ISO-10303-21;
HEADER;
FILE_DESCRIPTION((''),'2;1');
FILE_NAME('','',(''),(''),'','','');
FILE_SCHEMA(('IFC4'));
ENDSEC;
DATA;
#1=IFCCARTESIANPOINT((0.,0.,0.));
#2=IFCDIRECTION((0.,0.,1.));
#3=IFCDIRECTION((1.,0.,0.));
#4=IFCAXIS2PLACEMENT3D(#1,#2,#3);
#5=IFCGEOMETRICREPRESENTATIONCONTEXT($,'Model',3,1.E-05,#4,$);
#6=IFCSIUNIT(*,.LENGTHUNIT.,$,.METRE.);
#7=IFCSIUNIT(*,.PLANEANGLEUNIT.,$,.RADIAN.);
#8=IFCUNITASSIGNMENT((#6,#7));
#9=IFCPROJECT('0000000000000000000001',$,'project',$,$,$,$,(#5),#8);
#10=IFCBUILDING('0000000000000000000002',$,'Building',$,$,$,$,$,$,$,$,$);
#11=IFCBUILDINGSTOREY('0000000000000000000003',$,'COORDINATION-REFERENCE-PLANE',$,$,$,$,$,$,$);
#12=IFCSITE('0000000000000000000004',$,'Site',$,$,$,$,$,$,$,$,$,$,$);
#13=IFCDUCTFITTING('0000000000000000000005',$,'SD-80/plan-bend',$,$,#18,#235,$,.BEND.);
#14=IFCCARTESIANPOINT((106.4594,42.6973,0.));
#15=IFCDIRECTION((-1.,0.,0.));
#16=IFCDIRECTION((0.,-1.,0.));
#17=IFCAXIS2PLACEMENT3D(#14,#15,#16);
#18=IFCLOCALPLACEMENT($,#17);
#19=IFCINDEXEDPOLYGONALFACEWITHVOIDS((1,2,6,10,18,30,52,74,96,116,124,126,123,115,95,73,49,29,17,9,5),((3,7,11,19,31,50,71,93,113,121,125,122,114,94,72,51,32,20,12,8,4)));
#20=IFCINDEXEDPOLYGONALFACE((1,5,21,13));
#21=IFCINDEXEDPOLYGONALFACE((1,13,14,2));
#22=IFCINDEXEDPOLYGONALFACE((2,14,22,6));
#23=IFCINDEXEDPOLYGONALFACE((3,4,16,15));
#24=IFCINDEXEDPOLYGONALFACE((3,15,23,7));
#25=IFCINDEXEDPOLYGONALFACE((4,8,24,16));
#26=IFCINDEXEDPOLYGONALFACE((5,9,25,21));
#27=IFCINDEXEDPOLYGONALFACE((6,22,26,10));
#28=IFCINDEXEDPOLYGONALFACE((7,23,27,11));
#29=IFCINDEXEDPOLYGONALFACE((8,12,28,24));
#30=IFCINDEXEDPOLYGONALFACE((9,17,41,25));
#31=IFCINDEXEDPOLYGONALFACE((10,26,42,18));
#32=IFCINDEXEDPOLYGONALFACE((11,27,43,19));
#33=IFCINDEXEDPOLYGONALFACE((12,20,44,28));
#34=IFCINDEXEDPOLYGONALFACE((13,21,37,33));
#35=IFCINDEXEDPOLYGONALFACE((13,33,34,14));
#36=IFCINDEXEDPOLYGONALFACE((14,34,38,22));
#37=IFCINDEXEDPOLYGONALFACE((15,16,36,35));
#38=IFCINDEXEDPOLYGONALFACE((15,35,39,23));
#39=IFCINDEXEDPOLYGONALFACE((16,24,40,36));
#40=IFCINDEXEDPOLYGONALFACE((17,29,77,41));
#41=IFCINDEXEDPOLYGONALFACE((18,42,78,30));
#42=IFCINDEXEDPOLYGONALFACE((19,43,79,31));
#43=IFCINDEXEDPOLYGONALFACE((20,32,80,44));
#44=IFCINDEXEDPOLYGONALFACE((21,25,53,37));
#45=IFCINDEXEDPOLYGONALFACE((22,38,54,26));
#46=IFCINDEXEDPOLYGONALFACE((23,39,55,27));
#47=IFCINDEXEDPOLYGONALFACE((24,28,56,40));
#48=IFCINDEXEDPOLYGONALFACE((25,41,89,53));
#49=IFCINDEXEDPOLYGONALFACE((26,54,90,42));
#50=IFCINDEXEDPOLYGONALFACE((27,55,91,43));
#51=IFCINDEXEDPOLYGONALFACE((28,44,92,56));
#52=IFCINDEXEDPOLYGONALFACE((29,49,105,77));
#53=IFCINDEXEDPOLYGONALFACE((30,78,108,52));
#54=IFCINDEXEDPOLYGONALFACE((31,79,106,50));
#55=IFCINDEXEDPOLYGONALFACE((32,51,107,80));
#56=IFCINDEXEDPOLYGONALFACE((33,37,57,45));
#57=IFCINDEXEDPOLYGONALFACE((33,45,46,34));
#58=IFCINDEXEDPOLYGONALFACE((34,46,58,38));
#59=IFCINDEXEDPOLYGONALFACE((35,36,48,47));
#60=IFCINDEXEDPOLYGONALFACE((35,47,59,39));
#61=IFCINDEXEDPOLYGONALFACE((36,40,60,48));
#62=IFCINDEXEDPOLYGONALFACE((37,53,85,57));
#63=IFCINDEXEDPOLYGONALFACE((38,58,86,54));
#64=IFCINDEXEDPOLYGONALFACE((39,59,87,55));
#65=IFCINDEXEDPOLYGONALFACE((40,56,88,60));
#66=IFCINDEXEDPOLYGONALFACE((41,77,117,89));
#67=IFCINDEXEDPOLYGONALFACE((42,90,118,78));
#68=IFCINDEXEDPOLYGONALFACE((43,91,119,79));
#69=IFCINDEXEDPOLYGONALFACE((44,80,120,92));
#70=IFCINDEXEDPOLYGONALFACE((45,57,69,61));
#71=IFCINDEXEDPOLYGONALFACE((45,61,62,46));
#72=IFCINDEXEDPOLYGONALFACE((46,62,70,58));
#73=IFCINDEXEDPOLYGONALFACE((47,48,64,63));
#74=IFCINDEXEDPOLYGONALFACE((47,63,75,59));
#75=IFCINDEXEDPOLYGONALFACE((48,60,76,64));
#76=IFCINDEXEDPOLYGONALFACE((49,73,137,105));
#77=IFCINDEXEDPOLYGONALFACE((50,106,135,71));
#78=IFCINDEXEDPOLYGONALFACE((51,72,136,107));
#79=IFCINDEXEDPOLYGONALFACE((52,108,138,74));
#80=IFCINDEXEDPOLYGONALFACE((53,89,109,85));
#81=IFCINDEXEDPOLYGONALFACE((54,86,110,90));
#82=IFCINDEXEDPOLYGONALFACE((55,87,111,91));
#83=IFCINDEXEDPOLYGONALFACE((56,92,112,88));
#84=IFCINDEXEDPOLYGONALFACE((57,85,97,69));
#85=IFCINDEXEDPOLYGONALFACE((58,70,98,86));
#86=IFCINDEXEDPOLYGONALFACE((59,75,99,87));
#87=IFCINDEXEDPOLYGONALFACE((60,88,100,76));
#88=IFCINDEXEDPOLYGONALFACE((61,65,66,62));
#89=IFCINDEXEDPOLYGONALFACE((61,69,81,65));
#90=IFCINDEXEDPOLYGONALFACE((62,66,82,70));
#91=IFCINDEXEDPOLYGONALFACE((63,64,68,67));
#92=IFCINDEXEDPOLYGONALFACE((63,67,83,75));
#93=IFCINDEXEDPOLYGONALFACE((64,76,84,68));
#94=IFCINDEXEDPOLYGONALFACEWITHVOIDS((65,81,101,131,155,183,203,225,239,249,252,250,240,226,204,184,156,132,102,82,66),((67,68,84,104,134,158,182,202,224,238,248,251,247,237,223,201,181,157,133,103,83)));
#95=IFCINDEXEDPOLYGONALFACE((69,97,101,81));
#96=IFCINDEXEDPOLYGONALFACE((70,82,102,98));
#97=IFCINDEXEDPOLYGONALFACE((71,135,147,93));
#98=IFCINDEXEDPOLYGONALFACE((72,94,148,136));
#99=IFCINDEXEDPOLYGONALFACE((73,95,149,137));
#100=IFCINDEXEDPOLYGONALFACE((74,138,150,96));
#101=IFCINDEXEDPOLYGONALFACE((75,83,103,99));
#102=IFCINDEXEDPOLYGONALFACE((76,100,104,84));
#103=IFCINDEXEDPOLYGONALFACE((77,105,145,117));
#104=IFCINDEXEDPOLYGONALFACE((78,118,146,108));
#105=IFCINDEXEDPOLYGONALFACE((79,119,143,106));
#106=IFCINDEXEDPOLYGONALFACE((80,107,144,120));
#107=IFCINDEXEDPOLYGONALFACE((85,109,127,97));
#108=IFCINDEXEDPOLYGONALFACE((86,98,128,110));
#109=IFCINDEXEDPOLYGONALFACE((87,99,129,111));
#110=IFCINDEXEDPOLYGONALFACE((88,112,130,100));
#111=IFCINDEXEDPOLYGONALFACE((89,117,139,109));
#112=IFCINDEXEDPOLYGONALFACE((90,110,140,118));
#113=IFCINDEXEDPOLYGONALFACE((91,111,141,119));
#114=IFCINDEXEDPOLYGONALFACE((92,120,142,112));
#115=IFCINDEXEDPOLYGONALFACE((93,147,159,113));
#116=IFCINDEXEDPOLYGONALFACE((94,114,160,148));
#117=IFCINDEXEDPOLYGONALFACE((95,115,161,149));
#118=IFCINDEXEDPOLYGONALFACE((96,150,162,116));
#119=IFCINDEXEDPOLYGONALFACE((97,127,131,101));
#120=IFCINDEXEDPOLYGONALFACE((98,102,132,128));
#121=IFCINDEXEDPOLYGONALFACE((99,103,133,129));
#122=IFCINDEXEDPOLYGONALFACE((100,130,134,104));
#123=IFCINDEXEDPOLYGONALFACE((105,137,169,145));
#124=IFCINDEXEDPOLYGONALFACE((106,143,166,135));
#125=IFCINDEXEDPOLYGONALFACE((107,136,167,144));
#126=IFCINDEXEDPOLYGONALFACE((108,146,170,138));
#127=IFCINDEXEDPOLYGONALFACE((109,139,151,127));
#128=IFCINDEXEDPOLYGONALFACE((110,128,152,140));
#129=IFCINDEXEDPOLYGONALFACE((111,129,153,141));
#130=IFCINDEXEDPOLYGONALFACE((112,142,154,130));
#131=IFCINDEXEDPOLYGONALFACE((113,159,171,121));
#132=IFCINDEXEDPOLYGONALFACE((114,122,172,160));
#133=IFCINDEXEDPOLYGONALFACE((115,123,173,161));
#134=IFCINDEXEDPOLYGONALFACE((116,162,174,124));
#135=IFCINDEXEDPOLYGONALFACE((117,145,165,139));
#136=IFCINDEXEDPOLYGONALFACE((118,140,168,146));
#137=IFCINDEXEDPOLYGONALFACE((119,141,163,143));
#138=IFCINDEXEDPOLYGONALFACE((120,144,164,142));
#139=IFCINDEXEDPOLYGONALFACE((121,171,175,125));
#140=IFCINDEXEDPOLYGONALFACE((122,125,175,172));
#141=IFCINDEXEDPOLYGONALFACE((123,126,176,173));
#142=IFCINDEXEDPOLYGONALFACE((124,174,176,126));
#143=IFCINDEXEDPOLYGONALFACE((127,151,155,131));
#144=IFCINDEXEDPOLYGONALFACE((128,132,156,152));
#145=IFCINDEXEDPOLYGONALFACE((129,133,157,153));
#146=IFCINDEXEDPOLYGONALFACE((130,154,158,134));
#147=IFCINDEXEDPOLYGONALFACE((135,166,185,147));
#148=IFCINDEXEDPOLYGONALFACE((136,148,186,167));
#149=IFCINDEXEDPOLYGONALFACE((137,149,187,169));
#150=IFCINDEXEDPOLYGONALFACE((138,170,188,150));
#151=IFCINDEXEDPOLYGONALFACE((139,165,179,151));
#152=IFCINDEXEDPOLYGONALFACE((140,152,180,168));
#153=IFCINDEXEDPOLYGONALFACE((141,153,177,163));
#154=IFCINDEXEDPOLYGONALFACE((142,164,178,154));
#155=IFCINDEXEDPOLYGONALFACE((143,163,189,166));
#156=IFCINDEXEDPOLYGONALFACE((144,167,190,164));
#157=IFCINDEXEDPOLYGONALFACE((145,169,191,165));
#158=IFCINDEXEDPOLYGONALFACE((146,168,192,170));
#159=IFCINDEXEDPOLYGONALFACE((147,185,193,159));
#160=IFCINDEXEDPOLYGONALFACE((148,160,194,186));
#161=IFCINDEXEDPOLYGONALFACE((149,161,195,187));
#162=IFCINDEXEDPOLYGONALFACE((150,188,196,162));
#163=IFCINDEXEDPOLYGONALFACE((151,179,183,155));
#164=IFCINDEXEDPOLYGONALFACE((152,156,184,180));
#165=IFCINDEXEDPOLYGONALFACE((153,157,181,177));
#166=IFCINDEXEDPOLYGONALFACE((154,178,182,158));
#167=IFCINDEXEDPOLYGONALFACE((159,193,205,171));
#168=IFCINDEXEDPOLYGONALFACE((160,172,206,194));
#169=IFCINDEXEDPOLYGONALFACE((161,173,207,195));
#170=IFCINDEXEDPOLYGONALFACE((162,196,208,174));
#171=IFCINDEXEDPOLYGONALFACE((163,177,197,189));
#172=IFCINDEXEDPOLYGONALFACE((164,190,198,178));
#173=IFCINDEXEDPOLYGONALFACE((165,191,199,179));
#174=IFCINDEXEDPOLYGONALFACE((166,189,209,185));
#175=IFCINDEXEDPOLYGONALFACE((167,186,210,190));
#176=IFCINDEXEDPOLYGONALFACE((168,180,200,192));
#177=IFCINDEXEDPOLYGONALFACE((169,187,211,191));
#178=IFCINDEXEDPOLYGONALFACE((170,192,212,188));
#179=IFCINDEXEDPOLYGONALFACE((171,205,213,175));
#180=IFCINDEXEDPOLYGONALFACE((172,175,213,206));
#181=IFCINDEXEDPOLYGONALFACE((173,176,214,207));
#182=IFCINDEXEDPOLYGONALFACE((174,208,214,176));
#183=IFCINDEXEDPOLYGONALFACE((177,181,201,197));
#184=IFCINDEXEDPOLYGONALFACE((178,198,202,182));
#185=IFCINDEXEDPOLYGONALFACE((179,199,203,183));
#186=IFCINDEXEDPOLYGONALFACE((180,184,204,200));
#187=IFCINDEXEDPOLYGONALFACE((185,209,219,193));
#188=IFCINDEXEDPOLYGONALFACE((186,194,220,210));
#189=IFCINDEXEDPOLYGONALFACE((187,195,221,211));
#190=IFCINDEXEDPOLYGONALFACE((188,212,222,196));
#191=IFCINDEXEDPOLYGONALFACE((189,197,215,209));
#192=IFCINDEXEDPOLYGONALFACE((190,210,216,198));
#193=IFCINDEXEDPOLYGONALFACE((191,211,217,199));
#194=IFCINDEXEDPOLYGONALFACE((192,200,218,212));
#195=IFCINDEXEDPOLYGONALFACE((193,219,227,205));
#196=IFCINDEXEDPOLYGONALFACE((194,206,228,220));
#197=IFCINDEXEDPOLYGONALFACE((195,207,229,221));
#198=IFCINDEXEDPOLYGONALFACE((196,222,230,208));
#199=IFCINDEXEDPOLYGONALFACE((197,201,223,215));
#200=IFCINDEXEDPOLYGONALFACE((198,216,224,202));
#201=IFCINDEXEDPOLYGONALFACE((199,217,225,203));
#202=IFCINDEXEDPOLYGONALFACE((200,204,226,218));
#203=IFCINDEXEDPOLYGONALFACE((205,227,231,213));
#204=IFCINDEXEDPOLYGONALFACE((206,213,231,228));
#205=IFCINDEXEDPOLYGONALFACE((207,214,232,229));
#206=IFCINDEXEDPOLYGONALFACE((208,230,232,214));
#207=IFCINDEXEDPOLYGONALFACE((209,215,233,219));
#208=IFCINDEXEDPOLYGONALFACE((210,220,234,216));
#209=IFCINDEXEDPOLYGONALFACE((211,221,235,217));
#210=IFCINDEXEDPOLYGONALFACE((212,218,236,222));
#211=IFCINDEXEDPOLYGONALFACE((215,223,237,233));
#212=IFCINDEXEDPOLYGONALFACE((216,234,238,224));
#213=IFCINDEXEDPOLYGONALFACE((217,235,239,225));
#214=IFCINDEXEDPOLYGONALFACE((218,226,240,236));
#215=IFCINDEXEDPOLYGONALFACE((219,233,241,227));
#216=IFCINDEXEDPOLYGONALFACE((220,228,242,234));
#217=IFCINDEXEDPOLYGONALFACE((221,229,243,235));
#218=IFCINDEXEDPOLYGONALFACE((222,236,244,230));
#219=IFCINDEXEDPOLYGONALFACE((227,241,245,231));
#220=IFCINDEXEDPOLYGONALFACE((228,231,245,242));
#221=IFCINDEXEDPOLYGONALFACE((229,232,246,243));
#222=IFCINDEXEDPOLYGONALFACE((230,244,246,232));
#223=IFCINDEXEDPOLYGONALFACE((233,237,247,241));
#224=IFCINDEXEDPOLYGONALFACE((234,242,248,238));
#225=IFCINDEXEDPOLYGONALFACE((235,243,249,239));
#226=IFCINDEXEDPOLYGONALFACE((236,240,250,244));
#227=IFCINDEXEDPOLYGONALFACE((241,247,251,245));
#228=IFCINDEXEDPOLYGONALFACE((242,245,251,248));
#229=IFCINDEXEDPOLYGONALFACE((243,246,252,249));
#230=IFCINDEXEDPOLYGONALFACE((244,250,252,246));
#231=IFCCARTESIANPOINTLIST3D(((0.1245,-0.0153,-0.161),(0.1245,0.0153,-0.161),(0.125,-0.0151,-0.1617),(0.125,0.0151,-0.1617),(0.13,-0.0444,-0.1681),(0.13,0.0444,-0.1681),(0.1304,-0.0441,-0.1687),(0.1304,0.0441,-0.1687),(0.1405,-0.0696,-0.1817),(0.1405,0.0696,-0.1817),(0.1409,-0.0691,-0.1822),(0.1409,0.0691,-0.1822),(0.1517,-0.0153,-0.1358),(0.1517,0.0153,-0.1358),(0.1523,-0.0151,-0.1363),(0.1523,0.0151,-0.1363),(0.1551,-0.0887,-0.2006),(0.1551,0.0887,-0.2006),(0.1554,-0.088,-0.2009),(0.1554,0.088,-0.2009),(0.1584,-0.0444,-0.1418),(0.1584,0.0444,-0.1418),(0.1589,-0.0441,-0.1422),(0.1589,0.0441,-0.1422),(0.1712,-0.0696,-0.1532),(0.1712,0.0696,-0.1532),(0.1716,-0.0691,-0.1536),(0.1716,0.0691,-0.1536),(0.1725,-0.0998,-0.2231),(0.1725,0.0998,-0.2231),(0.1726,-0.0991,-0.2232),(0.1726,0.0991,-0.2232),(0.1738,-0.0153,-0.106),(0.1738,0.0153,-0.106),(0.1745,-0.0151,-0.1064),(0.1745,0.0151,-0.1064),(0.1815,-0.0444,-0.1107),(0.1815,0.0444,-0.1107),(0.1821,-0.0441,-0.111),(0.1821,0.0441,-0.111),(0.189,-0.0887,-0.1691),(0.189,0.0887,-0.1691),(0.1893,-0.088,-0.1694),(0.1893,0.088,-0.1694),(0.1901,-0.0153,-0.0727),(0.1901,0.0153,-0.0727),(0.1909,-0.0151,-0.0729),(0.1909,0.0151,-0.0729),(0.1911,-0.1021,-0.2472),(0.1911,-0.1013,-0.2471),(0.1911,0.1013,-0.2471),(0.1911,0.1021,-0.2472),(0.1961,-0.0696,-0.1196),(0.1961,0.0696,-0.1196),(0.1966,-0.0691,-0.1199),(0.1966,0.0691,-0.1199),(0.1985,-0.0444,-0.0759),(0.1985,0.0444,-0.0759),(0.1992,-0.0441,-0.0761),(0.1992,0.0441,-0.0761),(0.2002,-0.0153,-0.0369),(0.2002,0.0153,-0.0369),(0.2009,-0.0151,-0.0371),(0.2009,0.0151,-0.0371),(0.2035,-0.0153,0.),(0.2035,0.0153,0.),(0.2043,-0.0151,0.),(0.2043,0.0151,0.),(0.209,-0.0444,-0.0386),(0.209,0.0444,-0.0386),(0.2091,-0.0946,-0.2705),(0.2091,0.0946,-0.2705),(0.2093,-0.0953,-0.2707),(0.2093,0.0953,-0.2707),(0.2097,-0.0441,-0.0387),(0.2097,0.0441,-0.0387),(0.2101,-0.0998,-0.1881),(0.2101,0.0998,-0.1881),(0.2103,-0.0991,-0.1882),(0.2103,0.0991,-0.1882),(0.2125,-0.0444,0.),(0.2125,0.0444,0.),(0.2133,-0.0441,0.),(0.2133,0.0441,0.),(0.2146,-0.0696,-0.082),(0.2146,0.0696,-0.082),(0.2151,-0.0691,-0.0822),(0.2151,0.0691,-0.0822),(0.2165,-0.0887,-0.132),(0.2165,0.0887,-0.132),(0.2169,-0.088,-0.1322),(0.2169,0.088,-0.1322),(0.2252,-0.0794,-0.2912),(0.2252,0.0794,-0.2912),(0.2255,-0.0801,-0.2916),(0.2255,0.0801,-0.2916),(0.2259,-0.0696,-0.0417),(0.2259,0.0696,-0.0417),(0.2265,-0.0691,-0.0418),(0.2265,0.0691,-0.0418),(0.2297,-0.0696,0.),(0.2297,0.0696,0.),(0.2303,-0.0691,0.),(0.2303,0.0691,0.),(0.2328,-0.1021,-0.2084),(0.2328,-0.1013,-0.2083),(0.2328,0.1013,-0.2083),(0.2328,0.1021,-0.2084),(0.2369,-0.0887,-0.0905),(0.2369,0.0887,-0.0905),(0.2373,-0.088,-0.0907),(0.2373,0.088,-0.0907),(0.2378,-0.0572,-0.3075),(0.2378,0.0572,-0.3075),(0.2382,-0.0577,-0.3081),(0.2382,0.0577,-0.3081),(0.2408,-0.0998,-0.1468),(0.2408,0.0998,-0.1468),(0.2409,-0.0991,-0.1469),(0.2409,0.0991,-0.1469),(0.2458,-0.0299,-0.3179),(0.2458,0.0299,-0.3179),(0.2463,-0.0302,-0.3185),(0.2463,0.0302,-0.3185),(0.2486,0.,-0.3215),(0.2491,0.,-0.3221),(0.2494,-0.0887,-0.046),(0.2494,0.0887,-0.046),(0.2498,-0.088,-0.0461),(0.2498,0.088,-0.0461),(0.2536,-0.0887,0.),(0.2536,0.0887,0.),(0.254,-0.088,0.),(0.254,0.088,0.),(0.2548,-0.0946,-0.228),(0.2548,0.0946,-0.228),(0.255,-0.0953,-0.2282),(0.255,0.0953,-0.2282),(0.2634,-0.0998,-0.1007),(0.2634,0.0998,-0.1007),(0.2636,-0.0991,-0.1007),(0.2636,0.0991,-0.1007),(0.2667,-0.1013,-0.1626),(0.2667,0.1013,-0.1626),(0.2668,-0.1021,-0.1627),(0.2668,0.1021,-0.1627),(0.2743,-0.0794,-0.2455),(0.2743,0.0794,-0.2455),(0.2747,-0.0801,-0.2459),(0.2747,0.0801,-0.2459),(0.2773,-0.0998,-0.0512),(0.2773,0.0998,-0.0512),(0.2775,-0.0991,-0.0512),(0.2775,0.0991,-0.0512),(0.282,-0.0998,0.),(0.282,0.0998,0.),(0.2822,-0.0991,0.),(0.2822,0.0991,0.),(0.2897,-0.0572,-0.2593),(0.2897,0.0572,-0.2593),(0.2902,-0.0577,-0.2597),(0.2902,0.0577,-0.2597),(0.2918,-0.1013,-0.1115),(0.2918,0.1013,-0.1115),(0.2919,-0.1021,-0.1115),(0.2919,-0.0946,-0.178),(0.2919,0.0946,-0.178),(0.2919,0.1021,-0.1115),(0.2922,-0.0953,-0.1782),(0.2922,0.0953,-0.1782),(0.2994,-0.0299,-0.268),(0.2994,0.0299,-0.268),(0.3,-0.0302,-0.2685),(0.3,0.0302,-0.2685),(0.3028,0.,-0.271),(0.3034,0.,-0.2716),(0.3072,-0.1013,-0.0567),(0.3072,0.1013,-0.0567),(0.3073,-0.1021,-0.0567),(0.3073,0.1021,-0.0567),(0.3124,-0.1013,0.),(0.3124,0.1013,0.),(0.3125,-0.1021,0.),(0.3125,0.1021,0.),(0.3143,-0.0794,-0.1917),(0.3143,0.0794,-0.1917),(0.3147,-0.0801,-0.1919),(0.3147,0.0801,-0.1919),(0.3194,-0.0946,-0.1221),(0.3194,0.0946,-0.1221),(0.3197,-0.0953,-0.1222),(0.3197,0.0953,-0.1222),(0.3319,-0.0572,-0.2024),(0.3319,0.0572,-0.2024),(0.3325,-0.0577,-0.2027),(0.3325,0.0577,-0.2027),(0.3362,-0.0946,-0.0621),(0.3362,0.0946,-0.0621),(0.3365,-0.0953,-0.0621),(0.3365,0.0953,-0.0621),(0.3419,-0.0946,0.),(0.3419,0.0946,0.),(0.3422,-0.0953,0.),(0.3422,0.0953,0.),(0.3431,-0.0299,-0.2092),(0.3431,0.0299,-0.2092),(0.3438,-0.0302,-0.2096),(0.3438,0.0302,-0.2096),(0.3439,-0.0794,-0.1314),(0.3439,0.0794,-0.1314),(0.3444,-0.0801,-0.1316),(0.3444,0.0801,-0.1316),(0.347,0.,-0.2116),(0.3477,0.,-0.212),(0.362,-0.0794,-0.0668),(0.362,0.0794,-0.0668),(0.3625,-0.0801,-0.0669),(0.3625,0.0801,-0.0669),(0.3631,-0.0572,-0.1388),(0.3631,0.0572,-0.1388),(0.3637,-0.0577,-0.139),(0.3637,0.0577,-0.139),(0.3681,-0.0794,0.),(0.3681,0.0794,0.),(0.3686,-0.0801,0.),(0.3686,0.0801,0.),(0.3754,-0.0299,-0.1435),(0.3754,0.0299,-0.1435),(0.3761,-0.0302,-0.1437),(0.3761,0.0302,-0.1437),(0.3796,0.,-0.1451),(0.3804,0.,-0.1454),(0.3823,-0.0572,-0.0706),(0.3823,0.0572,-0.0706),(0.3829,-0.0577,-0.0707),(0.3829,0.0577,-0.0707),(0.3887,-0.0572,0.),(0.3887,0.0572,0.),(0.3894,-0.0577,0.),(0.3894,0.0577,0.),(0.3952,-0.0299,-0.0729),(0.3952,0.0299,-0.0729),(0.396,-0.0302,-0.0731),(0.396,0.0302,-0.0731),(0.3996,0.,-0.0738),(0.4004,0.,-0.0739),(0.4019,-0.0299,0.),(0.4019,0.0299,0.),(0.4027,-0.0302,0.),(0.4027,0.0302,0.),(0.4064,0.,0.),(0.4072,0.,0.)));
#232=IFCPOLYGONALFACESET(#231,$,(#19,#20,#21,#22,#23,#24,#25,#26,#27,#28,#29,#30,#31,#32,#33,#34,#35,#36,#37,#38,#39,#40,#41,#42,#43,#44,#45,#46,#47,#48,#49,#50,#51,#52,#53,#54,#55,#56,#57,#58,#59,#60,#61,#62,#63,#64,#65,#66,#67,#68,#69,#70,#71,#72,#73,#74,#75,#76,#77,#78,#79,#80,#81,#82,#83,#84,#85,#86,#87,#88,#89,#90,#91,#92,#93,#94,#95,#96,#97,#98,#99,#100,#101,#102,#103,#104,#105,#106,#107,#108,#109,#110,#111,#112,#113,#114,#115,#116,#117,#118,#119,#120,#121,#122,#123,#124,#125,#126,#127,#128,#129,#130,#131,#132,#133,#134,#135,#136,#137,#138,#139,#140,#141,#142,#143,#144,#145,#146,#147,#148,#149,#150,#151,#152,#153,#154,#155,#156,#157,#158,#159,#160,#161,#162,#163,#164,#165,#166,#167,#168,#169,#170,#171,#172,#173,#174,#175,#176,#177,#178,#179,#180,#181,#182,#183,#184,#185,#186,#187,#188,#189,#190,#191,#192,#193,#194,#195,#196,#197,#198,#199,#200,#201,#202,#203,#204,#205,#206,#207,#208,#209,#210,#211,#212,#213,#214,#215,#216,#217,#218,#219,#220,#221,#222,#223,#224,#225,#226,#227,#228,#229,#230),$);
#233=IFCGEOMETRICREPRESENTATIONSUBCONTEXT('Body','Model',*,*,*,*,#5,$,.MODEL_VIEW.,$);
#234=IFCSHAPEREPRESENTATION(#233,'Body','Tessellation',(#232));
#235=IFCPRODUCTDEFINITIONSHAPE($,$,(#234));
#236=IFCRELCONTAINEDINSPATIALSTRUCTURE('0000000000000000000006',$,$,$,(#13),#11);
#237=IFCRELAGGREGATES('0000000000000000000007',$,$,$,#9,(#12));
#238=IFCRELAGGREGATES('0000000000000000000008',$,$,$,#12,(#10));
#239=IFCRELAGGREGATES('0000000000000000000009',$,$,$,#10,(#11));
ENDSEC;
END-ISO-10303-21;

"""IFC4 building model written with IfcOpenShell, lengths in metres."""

from ifc_helpers import new_model, entity, si_unit, frame, origin_with_axes, place, context, subcontext, project, spatial, element, save


model = new_model("IFC4")

# Units and contexts
model_context = context("Model", 3, precision=1e-05, world=origin_with_axes())
body_context_1 = subcontext(model_context, "Body", "Model", "MODEL_VIEW")
ifc_project = project(units=[si_unit("LENGTHUNIT", "METRE"), si_unit("PLANEANGLEUNIT", "RADIAN")], contexts=[model_context])

# Site, building, storey
site = spatial("IfcSite", under=ifc_project, Name="Site")
building = spatial("IfcBuilding", under=site, Name="Building")
storey = spatial("IfcBuildingStorey", under=building, Name="COORDINATION-REFERENCE-PLANE")

# Duct fitting
duct_fitting_1_placement = place(None, frame((106.4594, 42.6973, 0.0), z_axis=(-1.0, 0.0, 0.0), x_axis=(0.0, -1.0, 0.0)))
element("IfcDuctFitting", 1, at=duct_fitting_1_placement, inside=storey, Name="SD-80/plan-bend", PredefinedType="BEND", context=body_context_1, shape_type="SweptSolid", body=[
    entity("IfcRevolvedAreaSolid", entity("IfcCircleHollowProfileDef", "AREA", None, entity("IfcAxis2Placement2D", entity("IfcCartesianPoint", [0.3048, 0.0])), 0.1024, 0.0008), entity("IfcAxis2Placement3D", entity("IfcCartesianPoint", [0.0, 0.0, 0.0]), entity("IfcDirection", [0.0, 0.0, 1.0]), entity("IfcDirection", [1.0, 0.0, 0.0])), entity("IfcAxis1Placement", entity("IfcCartesianPoint", [0.0, 0.0, 0.0]), entity("IfcDirection", [0.0, 1.0, 0.0])), 0.912619),
])

save(model, "model.ifc")
